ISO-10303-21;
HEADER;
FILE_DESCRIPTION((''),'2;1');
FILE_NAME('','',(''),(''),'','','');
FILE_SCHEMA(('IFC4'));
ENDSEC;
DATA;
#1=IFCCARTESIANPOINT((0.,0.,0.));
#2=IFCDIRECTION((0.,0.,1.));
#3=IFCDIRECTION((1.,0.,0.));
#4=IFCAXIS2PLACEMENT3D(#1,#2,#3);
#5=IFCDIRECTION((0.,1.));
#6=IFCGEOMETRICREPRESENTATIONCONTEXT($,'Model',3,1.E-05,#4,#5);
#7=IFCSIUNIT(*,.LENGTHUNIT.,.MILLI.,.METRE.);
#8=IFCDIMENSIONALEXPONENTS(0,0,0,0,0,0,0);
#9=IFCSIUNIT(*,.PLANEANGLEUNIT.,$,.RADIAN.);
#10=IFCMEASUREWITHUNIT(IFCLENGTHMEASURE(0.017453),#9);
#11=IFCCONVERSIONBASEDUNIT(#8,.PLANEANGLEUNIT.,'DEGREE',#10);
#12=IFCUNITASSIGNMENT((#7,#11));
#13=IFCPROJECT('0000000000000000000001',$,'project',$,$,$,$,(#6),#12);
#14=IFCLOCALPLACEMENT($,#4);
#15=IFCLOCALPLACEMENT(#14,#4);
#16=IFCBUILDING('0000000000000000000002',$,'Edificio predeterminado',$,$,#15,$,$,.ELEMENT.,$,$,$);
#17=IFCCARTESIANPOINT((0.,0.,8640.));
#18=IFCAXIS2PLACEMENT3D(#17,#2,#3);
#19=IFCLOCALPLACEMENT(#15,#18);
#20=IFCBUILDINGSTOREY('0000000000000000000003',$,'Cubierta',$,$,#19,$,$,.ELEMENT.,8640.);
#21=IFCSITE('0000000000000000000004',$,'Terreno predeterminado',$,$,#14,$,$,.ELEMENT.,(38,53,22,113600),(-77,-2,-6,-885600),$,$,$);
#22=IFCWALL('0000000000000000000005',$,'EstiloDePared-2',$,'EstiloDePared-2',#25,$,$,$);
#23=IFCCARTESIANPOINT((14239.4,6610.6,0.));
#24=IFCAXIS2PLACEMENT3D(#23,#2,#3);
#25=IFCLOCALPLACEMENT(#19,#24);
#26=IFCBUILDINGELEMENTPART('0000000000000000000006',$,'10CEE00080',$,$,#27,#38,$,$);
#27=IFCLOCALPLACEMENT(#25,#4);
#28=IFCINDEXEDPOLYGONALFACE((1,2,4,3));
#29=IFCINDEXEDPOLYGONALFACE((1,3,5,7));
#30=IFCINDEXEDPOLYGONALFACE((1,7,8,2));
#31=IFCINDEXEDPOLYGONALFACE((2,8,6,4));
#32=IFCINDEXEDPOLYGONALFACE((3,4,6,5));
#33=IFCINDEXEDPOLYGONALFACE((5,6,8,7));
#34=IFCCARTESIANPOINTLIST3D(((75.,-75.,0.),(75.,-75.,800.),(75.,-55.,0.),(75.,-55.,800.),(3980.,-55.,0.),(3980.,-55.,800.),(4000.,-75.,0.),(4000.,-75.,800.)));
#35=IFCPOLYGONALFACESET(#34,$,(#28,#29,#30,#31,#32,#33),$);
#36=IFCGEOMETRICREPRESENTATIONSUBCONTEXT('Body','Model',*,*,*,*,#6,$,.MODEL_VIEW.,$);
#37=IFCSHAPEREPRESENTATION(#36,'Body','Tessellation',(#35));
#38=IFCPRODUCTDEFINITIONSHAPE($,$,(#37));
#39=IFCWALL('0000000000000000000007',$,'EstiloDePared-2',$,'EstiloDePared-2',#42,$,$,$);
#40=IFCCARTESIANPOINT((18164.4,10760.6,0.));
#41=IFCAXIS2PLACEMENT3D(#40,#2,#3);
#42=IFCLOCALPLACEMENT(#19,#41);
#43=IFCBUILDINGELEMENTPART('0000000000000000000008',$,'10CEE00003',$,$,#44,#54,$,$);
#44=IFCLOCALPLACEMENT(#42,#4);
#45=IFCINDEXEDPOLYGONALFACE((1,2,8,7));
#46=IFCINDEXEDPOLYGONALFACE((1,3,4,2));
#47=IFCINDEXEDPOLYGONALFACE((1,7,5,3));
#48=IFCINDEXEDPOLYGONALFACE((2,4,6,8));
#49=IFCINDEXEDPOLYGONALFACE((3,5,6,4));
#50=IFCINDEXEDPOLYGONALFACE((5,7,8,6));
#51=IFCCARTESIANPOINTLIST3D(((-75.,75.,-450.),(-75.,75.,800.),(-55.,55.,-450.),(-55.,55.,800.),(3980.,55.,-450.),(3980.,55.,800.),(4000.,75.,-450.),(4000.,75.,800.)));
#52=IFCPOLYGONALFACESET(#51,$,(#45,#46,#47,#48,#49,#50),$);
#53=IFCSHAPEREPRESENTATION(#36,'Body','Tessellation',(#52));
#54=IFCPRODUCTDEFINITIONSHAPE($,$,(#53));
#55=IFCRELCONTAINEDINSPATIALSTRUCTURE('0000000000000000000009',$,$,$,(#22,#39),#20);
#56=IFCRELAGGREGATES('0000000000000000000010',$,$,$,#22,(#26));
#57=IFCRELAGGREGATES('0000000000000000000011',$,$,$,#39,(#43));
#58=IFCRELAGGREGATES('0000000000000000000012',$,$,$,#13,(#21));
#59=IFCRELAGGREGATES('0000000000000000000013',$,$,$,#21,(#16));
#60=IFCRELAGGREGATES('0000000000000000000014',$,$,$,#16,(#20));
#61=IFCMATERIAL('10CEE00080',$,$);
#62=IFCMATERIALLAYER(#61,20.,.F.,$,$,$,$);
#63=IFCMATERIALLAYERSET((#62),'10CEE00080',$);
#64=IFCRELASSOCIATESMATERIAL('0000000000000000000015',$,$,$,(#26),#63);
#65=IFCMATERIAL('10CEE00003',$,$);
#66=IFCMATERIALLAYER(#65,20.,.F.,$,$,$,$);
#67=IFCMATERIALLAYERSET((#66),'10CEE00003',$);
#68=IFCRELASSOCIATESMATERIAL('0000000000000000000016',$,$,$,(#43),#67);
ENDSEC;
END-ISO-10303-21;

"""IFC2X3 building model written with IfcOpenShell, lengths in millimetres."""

from ifc_helpers import new_model, entity, si_unit, converted_unit, direction, frame, origin_with_axes, place, context, subcontext, project, spatial, polyline, outline, extrude, material, layer, layer_set, layer_usage, element, aggregate, save


model = new_model("IFC2X3")

# Units and contexts
model_context = context("Model", 3, precision=1e-05, world=origin_with_axes(), true_north=direction((0.0, 1.0)))
body_context = subcontext(model_context, "Body", "Model", "MODEL_VIEW")
ifc_project = project(units=[si_unit("LENGTHUNIT", "METRE", prefix="MILLI"), converted_unit("PLANEANGLEUNIT", "DEGREE", entity("IfcLengthMeasure", 0.017453), si_unit("PLANEANGLEUNIT", "RADIAN"), dimensions=[0, 0, 0, 0, 0, 0, 0])], contexts=[model_context])

# Site, building, storey
site_placement = place(None, origin_with_axes())
site = spatial("IfcSite", under=ifc_project, at=site_placement, Name="Terreno predeterminado", CompositionType="ELEMENT", RefLatitude=(38, 53, 22, 113600), RefLongitude=(-77, -2, -6, -885600))
building_placement = place(site_placement, origin_with_axes())
building = spatial("IfcBuilding", under=site, at=building_placement, Name="Edificio predeterminado", CompositionType="ELEMENT")
storey_placement = place(building_placement, frame((0.0, 0.0, 8640.0), z_axis=(0.0, 0.0, 1.0), x_axis=(1.0, 0.0, 0.0)))
storey = spatial("IfcBuildingStorey", under=building, at=storey_placement, Name="Cubierta", CompositionType="ELEMENT", Elevation=8640.0)

# Walls, building element parts
wall_1_placement = place(storey_placement, frame((14239.4, 6610.6, 0.0), z_axis=(0.0, 0.0, 1.0), x_axis=(1.0, 0.0, 0.0)))
wall_1 = element("IfcWall", 1, at=wall_1_placement, inside=storey, Name="EstiloDePared-2", ObjectType="EstiloDePared-2")
ifc_material_1 = material(Name="10CEE00080")
ifc_layer_1 = layer(ifc_material_1, 20.0, ventilated=False)
ifc_layer_set_1 = layer_set([ifc_layer_1], Name="10CEE00080")
ifc_layer_usage_1 = layer_usage(ifc_layer_set_1, "AXIS2", "NEGATIVE", 55.0)
building_element_part_1_placement = place(wall_1_placement, origin_with_axes())
building_element_part_1 = element("IfcBuildingElementPart", 2, at=building_element_part_1_placement, material=ifc_layer_usage_1, Name="10CEE00080", context=body_context, shape_type="SweptSolid", body=[
    extrude(outline(polyline([(3980.0, -55.0), (4000.0, -75.0), (75.0, -75.0), (75.0, -55.0), (3980.0, -55.0)])), origin_with_axes(), (0.0, 0.0, 1.0), 800.0),
])
aggregate(wall_1, [building_element_part_1])
wall_2_placement = place(storey_placement, frame((18164.4, 10760.6, 0.0), z_axis=(0.0, 0.0, 1.0), x_axis=(1.0, 0.0, 0.0)))
wall_2 = element("IfcWall", 3, at=wall_2_placement, inside=storey, Name="EstiloDePared-2", ObjectType="EstiloDePared-2")
ifc_material_2 = material(Name="10CEE00003")
ifc_layer_2 = layer(ifc_material_2, 20.0, ventilated=False)
ifc_layer_set_2 = layer_set([ifc_layer_2], Name="10CEE00003")
ifc_layer_usage_2 = layer_usage(ifc_layer_set_2, "AXIS2", "NEGATIVE", -75.0)
building_element_part_2_placement = place(wall_2_placement, origin_with_axes())
building_element_part_2 = element("IfcBuildingElementPart", 4, at=building_element_part_2_placement, material=ifc_layer_usage_2, Name="10CEE00003", context=body_context, shape_type="SweptSolid", body=[
    extrude(outline(polyline([(4000.0, 75.0), (3980.0, 55.0), (-55.0, 55.0), (-75.0, 75.0), (4000.0, 75.0)])), frame((0.0, 0.0, -450.0), z_axis=(0.0, 0.0, 1.0), x_axis=(1.0, 0.0, 0.0)), (0.0, 0.0, 1.0), 1250.0),
])
aggregate(wall_2, [building_element_part_2])

save(model, "model.ifc")
